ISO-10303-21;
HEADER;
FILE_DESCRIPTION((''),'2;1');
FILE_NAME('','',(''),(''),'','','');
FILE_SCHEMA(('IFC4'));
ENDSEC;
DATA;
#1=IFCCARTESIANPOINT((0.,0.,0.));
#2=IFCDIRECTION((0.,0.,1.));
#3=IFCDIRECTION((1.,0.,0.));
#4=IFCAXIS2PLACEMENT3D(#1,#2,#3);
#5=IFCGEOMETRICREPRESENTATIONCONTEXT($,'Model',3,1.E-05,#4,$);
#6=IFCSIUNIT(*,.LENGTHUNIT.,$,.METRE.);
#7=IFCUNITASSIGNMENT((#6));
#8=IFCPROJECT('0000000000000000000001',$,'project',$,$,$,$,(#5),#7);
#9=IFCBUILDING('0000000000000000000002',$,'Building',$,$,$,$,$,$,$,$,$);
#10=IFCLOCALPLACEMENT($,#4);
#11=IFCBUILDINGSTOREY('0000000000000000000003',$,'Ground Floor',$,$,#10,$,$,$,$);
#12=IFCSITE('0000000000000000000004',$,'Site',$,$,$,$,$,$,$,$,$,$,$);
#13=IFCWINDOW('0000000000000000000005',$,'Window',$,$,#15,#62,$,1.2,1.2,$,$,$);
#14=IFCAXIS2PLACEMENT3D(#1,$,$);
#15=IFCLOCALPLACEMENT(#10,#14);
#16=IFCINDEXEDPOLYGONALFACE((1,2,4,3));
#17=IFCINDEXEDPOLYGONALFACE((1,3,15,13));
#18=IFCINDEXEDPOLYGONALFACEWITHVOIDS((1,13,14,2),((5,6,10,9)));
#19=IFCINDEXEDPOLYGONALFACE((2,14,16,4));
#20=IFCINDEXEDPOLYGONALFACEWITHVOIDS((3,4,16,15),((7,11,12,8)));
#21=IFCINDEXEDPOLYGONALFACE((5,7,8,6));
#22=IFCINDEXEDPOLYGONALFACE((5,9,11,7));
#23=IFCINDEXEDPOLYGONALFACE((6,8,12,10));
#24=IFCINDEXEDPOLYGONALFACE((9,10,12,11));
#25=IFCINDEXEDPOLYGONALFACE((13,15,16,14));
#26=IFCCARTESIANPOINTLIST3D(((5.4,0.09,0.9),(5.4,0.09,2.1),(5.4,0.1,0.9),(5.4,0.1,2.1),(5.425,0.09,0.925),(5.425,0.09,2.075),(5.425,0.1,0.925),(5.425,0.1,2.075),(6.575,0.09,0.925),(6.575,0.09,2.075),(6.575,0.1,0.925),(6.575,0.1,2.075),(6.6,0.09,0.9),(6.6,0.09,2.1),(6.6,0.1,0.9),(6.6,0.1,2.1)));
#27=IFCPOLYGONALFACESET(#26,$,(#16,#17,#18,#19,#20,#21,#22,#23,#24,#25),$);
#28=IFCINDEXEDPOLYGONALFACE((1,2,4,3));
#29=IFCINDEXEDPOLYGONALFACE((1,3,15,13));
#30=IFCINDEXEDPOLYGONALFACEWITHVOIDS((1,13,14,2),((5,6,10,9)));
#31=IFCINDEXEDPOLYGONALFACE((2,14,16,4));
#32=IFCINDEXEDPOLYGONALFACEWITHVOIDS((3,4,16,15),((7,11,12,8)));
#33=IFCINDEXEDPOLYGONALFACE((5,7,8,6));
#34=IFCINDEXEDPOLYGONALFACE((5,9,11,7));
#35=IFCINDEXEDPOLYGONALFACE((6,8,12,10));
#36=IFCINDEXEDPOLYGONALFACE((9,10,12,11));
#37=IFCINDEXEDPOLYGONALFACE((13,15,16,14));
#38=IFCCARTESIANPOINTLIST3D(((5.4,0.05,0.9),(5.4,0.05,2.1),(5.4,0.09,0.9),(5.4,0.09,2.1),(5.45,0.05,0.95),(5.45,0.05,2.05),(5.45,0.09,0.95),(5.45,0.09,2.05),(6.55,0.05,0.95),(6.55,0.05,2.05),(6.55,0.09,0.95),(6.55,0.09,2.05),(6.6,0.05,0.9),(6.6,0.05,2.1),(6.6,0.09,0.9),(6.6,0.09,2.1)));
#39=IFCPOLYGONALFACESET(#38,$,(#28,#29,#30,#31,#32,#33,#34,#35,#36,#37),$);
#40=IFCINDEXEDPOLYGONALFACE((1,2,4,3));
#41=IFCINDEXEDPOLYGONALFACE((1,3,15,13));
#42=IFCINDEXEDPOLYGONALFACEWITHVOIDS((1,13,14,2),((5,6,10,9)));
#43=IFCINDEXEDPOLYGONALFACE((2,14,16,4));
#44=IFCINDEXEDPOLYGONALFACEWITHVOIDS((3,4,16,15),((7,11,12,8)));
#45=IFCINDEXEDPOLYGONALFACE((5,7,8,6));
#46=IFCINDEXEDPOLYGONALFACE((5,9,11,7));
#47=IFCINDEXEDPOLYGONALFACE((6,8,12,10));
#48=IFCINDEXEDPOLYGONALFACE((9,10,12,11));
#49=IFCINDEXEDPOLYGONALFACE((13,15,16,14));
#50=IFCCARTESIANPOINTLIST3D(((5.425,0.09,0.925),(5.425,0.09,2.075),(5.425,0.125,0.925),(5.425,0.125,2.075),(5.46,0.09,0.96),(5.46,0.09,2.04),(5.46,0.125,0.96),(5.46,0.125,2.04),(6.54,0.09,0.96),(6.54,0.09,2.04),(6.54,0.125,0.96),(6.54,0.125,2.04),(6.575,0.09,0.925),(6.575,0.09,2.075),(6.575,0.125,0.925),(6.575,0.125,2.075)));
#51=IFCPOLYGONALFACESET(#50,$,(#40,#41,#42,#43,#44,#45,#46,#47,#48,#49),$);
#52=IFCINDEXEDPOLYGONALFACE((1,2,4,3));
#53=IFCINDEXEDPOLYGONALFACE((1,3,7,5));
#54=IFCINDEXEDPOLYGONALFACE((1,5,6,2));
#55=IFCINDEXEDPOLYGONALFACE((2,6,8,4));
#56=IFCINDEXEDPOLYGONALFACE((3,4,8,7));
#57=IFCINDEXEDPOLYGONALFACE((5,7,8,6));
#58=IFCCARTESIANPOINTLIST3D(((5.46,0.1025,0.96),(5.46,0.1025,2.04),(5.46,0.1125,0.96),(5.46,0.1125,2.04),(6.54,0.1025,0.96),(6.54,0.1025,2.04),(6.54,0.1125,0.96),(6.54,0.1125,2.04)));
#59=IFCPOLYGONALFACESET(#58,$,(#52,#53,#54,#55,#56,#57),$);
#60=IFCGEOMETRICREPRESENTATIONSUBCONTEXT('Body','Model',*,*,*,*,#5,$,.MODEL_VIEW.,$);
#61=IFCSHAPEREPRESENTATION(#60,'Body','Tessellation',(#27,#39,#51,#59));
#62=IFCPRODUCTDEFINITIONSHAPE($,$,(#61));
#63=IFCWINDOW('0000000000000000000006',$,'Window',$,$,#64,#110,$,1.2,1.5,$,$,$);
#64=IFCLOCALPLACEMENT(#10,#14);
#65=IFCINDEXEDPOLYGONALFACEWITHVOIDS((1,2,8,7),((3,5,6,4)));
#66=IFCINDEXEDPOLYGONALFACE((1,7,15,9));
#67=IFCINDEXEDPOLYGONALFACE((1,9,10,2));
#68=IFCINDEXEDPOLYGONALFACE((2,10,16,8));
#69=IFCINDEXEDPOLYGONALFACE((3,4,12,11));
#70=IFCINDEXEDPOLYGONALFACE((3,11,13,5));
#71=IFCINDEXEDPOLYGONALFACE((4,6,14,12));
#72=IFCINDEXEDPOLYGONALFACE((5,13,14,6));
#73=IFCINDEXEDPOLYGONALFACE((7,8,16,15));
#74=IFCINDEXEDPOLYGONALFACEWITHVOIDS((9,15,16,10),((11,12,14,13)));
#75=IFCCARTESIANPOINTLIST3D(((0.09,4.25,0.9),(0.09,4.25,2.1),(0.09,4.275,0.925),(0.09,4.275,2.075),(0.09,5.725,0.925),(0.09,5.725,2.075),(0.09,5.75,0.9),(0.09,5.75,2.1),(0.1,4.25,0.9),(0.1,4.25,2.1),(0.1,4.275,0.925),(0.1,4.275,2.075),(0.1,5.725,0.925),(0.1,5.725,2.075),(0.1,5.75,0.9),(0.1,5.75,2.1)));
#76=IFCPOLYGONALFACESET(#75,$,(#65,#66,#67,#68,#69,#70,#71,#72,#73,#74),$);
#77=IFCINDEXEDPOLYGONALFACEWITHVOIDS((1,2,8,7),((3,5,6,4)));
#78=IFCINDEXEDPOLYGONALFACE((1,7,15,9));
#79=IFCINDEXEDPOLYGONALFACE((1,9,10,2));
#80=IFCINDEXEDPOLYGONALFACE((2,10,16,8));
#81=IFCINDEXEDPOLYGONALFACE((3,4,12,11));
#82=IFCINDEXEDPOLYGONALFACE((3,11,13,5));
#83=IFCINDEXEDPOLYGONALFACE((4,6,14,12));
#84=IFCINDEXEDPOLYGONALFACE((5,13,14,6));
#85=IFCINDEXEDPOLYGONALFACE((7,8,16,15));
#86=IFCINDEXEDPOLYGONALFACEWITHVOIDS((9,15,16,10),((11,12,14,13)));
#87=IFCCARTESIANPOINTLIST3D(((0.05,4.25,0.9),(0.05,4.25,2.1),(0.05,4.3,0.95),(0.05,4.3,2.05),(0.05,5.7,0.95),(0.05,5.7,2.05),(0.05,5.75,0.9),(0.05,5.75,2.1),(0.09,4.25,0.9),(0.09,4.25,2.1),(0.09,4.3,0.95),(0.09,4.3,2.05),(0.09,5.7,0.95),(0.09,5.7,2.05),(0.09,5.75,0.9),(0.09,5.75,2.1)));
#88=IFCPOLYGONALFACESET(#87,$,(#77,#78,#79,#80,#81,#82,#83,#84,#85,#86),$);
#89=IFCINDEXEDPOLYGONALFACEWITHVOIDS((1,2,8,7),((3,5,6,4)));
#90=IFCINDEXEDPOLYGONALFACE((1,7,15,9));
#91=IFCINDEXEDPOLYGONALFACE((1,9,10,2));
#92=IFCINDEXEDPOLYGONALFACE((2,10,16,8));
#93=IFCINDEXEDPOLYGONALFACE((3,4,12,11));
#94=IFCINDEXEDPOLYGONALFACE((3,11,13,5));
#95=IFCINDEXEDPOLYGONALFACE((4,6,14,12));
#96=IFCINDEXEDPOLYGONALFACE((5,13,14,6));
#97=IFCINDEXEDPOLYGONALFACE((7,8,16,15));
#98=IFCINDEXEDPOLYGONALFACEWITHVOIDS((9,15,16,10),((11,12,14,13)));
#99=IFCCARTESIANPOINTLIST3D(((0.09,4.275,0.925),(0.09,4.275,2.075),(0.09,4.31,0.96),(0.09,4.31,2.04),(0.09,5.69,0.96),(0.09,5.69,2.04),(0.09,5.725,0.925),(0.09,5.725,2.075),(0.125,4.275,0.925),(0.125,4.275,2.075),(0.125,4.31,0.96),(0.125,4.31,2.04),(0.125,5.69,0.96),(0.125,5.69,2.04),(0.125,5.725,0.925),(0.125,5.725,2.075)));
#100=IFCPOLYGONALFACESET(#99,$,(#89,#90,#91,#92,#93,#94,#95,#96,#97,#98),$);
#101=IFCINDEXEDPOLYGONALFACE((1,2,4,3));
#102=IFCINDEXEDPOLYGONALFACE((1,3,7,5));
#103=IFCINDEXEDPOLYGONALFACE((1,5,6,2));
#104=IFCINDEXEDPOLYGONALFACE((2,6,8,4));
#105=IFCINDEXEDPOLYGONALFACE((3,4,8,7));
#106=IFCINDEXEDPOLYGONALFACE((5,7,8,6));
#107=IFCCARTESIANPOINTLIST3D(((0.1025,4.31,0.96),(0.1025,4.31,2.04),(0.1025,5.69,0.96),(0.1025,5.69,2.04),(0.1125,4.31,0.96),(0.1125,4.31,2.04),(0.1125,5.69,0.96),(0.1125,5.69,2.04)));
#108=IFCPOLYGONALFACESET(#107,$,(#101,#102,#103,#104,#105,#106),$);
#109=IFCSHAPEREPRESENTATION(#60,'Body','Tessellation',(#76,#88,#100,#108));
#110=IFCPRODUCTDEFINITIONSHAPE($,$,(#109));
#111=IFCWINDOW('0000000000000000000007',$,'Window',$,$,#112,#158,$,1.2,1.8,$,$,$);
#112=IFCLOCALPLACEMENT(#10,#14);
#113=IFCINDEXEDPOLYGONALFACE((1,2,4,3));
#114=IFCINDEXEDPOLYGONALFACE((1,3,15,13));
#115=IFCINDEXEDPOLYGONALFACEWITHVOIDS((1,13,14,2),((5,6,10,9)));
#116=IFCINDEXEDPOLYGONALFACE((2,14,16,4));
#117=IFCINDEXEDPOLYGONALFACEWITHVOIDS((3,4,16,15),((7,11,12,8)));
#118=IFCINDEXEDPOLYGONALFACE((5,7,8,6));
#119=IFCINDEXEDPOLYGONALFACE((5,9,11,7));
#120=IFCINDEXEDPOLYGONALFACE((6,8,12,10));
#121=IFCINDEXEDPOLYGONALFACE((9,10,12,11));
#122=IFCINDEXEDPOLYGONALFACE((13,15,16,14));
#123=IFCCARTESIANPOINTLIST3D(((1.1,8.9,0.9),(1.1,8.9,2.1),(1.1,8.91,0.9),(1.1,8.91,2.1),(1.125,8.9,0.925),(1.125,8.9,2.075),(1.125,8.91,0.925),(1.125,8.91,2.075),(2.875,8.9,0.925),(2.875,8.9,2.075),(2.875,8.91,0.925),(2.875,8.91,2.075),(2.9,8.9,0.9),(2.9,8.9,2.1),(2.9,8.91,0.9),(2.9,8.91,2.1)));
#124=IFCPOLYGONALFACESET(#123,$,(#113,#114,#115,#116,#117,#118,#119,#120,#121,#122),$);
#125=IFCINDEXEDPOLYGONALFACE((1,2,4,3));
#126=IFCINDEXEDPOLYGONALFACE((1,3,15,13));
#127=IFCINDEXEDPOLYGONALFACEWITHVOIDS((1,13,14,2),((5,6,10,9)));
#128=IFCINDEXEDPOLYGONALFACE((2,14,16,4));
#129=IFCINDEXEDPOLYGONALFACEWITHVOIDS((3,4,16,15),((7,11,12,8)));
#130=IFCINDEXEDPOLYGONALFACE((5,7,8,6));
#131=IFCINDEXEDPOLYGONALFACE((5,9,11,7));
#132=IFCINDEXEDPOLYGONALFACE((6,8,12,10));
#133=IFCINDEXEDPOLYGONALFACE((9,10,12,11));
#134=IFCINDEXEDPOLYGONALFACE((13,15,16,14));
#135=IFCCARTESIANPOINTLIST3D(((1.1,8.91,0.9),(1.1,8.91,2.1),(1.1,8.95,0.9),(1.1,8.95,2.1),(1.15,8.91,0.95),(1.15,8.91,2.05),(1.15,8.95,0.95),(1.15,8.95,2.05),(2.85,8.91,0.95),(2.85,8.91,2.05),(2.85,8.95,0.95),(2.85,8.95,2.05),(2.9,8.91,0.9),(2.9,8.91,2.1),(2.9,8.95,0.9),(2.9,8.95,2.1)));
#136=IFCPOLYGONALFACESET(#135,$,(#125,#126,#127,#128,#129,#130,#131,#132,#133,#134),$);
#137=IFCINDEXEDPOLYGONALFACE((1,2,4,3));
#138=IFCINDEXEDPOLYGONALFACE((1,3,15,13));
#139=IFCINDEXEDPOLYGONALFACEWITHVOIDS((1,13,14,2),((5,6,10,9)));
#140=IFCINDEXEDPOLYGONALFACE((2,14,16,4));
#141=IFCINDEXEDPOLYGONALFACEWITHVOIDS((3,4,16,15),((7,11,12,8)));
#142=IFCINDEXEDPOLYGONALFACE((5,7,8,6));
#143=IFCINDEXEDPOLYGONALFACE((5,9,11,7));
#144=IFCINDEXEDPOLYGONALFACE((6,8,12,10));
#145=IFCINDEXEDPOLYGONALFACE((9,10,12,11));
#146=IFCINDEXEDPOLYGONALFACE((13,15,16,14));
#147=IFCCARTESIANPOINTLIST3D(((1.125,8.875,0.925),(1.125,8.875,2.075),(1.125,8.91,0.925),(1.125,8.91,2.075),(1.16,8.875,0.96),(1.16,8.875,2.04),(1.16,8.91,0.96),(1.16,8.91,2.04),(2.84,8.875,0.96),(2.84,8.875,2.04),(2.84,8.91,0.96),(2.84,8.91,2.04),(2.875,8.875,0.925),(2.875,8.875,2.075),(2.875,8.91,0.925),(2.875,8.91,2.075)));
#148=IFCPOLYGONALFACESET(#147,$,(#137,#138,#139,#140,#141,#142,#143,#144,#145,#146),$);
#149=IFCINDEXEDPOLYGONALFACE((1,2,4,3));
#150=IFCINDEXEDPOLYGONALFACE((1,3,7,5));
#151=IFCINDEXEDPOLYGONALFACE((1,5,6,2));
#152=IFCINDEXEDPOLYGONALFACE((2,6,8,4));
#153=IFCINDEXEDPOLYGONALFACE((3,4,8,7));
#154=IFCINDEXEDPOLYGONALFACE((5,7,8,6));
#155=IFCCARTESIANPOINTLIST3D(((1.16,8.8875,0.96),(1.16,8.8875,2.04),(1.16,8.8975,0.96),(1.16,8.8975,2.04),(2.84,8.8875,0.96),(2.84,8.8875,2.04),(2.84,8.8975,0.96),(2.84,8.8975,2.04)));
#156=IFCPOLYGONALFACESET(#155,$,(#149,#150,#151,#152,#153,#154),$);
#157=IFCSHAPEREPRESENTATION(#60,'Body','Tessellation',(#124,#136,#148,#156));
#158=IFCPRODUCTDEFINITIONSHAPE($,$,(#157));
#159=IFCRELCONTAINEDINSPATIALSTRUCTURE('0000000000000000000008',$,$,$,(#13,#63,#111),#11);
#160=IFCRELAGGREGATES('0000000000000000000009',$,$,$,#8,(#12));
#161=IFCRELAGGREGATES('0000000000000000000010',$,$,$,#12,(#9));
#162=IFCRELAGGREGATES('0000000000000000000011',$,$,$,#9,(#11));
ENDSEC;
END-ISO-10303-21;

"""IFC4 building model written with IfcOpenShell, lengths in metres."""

from ifc_helpers import new_model, si_unit, frame, origin_with_axes, place, context, subcontext, project, spatial, line, indexed_curve, outline, extrude, element, save


model = new_model("IFC4")

# Units and contexts
model_context = context("Model", 3, precision=1e-05, world=origin_with_axes())
body_context = subcontext(model_context, "Body", "Model", "MODEL_VIEW")
ifc_project = project(units=[si_unit("LENGTHUNIT", "METRE")], contexts=[model_context])

# Site, building, storey
site = spatial("IfcSite", under=ifc_project, Name="Site")
building = spatial("IfcBuilding", under=site, Name="Building")
storey_placement = place(None, origin_with_axes())
storey = spatial("IfcBuildingStorey", under=building, at=storey_placement, Name="Ground Floor")

# Windows
window_1_placement = place(storey_placement, frame((5.4, 0.0, 0.9), z_axis=(0.0, 0.0, 1.0), x_axis=(1.0, 0.0, 0.0)))
element("IfcWindow", 1, at=window_1_placement, inside=storey, Name="Window", OverallHeight=1.2, OverallWidth=1.2, context=body_context, shape_type="SweptSolid", body=[
    extrude(outline(indexed_curve([(0.0, 0.0), (1.2, 0.0), (1.2, 1.2), (0.0, 1.2)], segments=[line(1, 2, 3, 4, 1)]), holes=[indexed_curve([(0.025, 0.025), (1.175, 0.025), (1.175, 1.175), (0.025, 1.175)], segments=[line(1, 2, 3, 4, 1)])]), frame((0.0, 0.09, 0.0), z_axis=(0.0, -1.0, 0.0), x_axis=(1.0, 0.0, 0.0)), (0.0, 0.0, -1.0), 0.01),
    extrude(outline(indexed_curve([(0.0, 0.0), (1.2, 0.0), (1.2, 1.2), (0.0, 1.2)], segments=[line(1, 2, 3, 4, 1)]), holes=[indexed_curve([(0.05, 0.05), (1.15, 0.05), (1.15, 1.15), (0.05, 1.15)], segments=[line(1, 2, 3, 4, 1)])]), frame((0.0, 0.05, 0.0), z_axis=(0.0, -1.0, 0.0), x_axis=(1.0, 0.0, 0.0)), (0.0, 0.0, -1.0), 0.04),
    extrude(outline(indexed_curve([(0.0, 0.0), (1.15, 0.0), (1.15, 1.15), (0.0, 1.15)], segments=[line(1, 2, 3, 4, 1)]), holes=[indexed_curve([(0.035, 0.035), (1.115, 0.035), (1.115, 1.115), (0.035, 1.115)], segments=[line(1, 2, 3, 4, 1)])]), frame((0.025, 0.09, 0.025), z_axis=(0.0, -1.0, 0.0), x_axis=(1.0, 0.0, 0.0)), (0.0, 0.0, -1.0), 0.035),
    extrude(outline(indexed_curve([(0.035, 0.035), (1.115, 0.035), (1.115, 1.115), (0.035, 1.115)], segments=[line(1, 2, 3, 4, 1)])), frame((0.025, 0.1025, 0.025), z_axis=(0.0, -1.0, 0.0), x_axis=(1.0, 0.0, 0.0)), (0.0, 0.0, -1.0), 0.01),
])
window_2_placement = place(storey_placement, frame((0.0, 5.75, 0.9), z_axis=(0.0, 0.0, 1.0), x_axis=(0.0, -1.0, 0.0)))
element("IfcWindow", 2, at=window_2_placement, inside=storey, Name="Window", OverallHeight=1.2, OverallWidth=1.5, context=body_context, shape_type="SweptSolid", body=[
    extrude(outline(indexed_curve([(0.0, 0.0), (1.5, 0.0), (1.5, 1.2), (0.0, 1.2)], segments=[line(1, 2, 3, 4, 1)]), holes=[indexed_curve([(0.025, 0.025), (1.475, 0.025), (1.475, 1.175), (0.025, 1.175)], segments=[line(1, 2, 3, 4, 1)])]), frame((0.0, 0.09, 0.0), z_axis=(0.0, -1.0, 0.0), x_axis=(1.0, 0.0, 0.0)), (0.0, 0.0, -1.0), 0.01),
    extrude(outline(indexed_curve([(0.0, 0.0), (1.5, 0.0), (1.5, 1.2), (0.0, 1.2)], segments=[line(1, 2, 3, 4, 1)]), holes=[indexed_curve([(0.05, 0.05), (1.45, 0.05), (1.45, 1.15), (0.05, 1.15)], segments=[line(1, 2, 3, 4, 1)])]), frame((0.0, 0.05, 0.0), z_axis=(0.0, -1.0, 0.0), x_axis=(1.0, 0.0, 0.0)), (0.0, 0.0, -1.0), 0.04),
    extrude(outline(indexed_curve([(0.0, 0.0), (1.45, 0.0), (1.45, 1.15), (0.0, 1.15)], segments=[line(1, 2, 3, 4, 1)]), holes=[indexed_curve([(0.035, 0.035), (1.415, 0.035), (1.415, 1.115), (0.035, 1.115)], segments=[line(1, 2, 3, 4, 1)])]), frame((0.025, 0.09, 0.025), z_axis=(0.0, -1.0, 0.0), x_axis=(1.0, 0.0, 0.0)), (0.0, 0.0, -1.0), 0.035),
    extrude(outline(indexed_curve([(0.035, 0.035), (1.415, 0.035), (1.415, 1.115), (0.035, 1.115)], segments=[line(1, 2, 3, 4, 1)])), frame((0.025, 0.1025, 0.025), z_axis=(0.0, -1.0, 0.0), x_axis=(1.0, 0.0, 0.0)), (0.0, 0.0, -1.0), 0.01),
])
window_3_placement = place(storey_placement, frame((2.9, 9.0, 0.9), z_axis=(0.0, 0.0, 1.0), x_axis=(-1.0, 0.0, 0.0)))
element("IfcWindow", 3, at=window_3_placement, inside=storey, Name="Window", OverallHeight=1.2, OverallWidth=1.8, context=body_context, shape_type="SweptSolid", body=[
    extrude(outline(indexed_curve([(0.0, 0.0), (1.8, 0.0), (1.8, 1.2), (0.0, 1.2)], segments=[line(1, 2, 3, 4, 1)]), holes=[indexed_curve([(0.025, 0.025), (1.775, 0.025), (1.775, 1.175), (0.025, 1.175)], segments=[line(1, 2, 3, 4, 1)])]), frame((0.0, 0.09, 0.0), z_axis=(0.0, -1.0, 0.0), x_axis=(1.0, 0.0, 0.0)), (0.0, 0.0, -1.0), 0.01),
    extrude(outline(indexed_curve([(0.0, 0.0), (1.8, 0.0), (1.8, 1.2), (0.0, 1.2)], segments=[line(1, 2, 3, 4, 1)]), holes=[indexed_curve([(0.05, 0.05), (1.75, 0.05), (1.75, 1.15), (0.05, 1.15)], segments=[line(1, 2, 3, 4, 1)])]), frame((0.0, 0.05, 0.0), z_axis=(0.0, -1.0, 0.0), x_axis=(1.0, 0.0, 0.0)), (0.0, 0.0, -1.0), 0.04),
    extrude(outline(indexed_curve([(0.0, 0.0), (1.75, 0.0), (1.75, 1.15), (0.0, 1.15)], segments=[line(1, 2, 3, 4, 1)]), holes=[indexed_curve([(0.035, 0.035), (1.715, 0.035), (1.715, 1.115), (0.035, 1.115)], segments=[line(1, 2, 3, 4, 1)])]), frame((0.025, 0.09, 0.025), z_axis=(0.0, -1.0, 0.0), x_axis=(1.0, 0.0, 0.0)), (0.0, 0.0, -1.0), 0.035),
    extrude(outline(indexed_curve([(0.035, 0.035), (1.715, 0.035), (1.715, 1.115), (0.035, 1.115)], segments=[line(1, 2, 3, 4, 1)])), frame((0.025, 0.1025, 0.025), z_axis=(0.0, -1.0, 0.0), x_axis=(1.0, 0.0, 0.0)), (0.0, 0.0, -1.0), 0.01),
])

save(model, "model.ifc")
